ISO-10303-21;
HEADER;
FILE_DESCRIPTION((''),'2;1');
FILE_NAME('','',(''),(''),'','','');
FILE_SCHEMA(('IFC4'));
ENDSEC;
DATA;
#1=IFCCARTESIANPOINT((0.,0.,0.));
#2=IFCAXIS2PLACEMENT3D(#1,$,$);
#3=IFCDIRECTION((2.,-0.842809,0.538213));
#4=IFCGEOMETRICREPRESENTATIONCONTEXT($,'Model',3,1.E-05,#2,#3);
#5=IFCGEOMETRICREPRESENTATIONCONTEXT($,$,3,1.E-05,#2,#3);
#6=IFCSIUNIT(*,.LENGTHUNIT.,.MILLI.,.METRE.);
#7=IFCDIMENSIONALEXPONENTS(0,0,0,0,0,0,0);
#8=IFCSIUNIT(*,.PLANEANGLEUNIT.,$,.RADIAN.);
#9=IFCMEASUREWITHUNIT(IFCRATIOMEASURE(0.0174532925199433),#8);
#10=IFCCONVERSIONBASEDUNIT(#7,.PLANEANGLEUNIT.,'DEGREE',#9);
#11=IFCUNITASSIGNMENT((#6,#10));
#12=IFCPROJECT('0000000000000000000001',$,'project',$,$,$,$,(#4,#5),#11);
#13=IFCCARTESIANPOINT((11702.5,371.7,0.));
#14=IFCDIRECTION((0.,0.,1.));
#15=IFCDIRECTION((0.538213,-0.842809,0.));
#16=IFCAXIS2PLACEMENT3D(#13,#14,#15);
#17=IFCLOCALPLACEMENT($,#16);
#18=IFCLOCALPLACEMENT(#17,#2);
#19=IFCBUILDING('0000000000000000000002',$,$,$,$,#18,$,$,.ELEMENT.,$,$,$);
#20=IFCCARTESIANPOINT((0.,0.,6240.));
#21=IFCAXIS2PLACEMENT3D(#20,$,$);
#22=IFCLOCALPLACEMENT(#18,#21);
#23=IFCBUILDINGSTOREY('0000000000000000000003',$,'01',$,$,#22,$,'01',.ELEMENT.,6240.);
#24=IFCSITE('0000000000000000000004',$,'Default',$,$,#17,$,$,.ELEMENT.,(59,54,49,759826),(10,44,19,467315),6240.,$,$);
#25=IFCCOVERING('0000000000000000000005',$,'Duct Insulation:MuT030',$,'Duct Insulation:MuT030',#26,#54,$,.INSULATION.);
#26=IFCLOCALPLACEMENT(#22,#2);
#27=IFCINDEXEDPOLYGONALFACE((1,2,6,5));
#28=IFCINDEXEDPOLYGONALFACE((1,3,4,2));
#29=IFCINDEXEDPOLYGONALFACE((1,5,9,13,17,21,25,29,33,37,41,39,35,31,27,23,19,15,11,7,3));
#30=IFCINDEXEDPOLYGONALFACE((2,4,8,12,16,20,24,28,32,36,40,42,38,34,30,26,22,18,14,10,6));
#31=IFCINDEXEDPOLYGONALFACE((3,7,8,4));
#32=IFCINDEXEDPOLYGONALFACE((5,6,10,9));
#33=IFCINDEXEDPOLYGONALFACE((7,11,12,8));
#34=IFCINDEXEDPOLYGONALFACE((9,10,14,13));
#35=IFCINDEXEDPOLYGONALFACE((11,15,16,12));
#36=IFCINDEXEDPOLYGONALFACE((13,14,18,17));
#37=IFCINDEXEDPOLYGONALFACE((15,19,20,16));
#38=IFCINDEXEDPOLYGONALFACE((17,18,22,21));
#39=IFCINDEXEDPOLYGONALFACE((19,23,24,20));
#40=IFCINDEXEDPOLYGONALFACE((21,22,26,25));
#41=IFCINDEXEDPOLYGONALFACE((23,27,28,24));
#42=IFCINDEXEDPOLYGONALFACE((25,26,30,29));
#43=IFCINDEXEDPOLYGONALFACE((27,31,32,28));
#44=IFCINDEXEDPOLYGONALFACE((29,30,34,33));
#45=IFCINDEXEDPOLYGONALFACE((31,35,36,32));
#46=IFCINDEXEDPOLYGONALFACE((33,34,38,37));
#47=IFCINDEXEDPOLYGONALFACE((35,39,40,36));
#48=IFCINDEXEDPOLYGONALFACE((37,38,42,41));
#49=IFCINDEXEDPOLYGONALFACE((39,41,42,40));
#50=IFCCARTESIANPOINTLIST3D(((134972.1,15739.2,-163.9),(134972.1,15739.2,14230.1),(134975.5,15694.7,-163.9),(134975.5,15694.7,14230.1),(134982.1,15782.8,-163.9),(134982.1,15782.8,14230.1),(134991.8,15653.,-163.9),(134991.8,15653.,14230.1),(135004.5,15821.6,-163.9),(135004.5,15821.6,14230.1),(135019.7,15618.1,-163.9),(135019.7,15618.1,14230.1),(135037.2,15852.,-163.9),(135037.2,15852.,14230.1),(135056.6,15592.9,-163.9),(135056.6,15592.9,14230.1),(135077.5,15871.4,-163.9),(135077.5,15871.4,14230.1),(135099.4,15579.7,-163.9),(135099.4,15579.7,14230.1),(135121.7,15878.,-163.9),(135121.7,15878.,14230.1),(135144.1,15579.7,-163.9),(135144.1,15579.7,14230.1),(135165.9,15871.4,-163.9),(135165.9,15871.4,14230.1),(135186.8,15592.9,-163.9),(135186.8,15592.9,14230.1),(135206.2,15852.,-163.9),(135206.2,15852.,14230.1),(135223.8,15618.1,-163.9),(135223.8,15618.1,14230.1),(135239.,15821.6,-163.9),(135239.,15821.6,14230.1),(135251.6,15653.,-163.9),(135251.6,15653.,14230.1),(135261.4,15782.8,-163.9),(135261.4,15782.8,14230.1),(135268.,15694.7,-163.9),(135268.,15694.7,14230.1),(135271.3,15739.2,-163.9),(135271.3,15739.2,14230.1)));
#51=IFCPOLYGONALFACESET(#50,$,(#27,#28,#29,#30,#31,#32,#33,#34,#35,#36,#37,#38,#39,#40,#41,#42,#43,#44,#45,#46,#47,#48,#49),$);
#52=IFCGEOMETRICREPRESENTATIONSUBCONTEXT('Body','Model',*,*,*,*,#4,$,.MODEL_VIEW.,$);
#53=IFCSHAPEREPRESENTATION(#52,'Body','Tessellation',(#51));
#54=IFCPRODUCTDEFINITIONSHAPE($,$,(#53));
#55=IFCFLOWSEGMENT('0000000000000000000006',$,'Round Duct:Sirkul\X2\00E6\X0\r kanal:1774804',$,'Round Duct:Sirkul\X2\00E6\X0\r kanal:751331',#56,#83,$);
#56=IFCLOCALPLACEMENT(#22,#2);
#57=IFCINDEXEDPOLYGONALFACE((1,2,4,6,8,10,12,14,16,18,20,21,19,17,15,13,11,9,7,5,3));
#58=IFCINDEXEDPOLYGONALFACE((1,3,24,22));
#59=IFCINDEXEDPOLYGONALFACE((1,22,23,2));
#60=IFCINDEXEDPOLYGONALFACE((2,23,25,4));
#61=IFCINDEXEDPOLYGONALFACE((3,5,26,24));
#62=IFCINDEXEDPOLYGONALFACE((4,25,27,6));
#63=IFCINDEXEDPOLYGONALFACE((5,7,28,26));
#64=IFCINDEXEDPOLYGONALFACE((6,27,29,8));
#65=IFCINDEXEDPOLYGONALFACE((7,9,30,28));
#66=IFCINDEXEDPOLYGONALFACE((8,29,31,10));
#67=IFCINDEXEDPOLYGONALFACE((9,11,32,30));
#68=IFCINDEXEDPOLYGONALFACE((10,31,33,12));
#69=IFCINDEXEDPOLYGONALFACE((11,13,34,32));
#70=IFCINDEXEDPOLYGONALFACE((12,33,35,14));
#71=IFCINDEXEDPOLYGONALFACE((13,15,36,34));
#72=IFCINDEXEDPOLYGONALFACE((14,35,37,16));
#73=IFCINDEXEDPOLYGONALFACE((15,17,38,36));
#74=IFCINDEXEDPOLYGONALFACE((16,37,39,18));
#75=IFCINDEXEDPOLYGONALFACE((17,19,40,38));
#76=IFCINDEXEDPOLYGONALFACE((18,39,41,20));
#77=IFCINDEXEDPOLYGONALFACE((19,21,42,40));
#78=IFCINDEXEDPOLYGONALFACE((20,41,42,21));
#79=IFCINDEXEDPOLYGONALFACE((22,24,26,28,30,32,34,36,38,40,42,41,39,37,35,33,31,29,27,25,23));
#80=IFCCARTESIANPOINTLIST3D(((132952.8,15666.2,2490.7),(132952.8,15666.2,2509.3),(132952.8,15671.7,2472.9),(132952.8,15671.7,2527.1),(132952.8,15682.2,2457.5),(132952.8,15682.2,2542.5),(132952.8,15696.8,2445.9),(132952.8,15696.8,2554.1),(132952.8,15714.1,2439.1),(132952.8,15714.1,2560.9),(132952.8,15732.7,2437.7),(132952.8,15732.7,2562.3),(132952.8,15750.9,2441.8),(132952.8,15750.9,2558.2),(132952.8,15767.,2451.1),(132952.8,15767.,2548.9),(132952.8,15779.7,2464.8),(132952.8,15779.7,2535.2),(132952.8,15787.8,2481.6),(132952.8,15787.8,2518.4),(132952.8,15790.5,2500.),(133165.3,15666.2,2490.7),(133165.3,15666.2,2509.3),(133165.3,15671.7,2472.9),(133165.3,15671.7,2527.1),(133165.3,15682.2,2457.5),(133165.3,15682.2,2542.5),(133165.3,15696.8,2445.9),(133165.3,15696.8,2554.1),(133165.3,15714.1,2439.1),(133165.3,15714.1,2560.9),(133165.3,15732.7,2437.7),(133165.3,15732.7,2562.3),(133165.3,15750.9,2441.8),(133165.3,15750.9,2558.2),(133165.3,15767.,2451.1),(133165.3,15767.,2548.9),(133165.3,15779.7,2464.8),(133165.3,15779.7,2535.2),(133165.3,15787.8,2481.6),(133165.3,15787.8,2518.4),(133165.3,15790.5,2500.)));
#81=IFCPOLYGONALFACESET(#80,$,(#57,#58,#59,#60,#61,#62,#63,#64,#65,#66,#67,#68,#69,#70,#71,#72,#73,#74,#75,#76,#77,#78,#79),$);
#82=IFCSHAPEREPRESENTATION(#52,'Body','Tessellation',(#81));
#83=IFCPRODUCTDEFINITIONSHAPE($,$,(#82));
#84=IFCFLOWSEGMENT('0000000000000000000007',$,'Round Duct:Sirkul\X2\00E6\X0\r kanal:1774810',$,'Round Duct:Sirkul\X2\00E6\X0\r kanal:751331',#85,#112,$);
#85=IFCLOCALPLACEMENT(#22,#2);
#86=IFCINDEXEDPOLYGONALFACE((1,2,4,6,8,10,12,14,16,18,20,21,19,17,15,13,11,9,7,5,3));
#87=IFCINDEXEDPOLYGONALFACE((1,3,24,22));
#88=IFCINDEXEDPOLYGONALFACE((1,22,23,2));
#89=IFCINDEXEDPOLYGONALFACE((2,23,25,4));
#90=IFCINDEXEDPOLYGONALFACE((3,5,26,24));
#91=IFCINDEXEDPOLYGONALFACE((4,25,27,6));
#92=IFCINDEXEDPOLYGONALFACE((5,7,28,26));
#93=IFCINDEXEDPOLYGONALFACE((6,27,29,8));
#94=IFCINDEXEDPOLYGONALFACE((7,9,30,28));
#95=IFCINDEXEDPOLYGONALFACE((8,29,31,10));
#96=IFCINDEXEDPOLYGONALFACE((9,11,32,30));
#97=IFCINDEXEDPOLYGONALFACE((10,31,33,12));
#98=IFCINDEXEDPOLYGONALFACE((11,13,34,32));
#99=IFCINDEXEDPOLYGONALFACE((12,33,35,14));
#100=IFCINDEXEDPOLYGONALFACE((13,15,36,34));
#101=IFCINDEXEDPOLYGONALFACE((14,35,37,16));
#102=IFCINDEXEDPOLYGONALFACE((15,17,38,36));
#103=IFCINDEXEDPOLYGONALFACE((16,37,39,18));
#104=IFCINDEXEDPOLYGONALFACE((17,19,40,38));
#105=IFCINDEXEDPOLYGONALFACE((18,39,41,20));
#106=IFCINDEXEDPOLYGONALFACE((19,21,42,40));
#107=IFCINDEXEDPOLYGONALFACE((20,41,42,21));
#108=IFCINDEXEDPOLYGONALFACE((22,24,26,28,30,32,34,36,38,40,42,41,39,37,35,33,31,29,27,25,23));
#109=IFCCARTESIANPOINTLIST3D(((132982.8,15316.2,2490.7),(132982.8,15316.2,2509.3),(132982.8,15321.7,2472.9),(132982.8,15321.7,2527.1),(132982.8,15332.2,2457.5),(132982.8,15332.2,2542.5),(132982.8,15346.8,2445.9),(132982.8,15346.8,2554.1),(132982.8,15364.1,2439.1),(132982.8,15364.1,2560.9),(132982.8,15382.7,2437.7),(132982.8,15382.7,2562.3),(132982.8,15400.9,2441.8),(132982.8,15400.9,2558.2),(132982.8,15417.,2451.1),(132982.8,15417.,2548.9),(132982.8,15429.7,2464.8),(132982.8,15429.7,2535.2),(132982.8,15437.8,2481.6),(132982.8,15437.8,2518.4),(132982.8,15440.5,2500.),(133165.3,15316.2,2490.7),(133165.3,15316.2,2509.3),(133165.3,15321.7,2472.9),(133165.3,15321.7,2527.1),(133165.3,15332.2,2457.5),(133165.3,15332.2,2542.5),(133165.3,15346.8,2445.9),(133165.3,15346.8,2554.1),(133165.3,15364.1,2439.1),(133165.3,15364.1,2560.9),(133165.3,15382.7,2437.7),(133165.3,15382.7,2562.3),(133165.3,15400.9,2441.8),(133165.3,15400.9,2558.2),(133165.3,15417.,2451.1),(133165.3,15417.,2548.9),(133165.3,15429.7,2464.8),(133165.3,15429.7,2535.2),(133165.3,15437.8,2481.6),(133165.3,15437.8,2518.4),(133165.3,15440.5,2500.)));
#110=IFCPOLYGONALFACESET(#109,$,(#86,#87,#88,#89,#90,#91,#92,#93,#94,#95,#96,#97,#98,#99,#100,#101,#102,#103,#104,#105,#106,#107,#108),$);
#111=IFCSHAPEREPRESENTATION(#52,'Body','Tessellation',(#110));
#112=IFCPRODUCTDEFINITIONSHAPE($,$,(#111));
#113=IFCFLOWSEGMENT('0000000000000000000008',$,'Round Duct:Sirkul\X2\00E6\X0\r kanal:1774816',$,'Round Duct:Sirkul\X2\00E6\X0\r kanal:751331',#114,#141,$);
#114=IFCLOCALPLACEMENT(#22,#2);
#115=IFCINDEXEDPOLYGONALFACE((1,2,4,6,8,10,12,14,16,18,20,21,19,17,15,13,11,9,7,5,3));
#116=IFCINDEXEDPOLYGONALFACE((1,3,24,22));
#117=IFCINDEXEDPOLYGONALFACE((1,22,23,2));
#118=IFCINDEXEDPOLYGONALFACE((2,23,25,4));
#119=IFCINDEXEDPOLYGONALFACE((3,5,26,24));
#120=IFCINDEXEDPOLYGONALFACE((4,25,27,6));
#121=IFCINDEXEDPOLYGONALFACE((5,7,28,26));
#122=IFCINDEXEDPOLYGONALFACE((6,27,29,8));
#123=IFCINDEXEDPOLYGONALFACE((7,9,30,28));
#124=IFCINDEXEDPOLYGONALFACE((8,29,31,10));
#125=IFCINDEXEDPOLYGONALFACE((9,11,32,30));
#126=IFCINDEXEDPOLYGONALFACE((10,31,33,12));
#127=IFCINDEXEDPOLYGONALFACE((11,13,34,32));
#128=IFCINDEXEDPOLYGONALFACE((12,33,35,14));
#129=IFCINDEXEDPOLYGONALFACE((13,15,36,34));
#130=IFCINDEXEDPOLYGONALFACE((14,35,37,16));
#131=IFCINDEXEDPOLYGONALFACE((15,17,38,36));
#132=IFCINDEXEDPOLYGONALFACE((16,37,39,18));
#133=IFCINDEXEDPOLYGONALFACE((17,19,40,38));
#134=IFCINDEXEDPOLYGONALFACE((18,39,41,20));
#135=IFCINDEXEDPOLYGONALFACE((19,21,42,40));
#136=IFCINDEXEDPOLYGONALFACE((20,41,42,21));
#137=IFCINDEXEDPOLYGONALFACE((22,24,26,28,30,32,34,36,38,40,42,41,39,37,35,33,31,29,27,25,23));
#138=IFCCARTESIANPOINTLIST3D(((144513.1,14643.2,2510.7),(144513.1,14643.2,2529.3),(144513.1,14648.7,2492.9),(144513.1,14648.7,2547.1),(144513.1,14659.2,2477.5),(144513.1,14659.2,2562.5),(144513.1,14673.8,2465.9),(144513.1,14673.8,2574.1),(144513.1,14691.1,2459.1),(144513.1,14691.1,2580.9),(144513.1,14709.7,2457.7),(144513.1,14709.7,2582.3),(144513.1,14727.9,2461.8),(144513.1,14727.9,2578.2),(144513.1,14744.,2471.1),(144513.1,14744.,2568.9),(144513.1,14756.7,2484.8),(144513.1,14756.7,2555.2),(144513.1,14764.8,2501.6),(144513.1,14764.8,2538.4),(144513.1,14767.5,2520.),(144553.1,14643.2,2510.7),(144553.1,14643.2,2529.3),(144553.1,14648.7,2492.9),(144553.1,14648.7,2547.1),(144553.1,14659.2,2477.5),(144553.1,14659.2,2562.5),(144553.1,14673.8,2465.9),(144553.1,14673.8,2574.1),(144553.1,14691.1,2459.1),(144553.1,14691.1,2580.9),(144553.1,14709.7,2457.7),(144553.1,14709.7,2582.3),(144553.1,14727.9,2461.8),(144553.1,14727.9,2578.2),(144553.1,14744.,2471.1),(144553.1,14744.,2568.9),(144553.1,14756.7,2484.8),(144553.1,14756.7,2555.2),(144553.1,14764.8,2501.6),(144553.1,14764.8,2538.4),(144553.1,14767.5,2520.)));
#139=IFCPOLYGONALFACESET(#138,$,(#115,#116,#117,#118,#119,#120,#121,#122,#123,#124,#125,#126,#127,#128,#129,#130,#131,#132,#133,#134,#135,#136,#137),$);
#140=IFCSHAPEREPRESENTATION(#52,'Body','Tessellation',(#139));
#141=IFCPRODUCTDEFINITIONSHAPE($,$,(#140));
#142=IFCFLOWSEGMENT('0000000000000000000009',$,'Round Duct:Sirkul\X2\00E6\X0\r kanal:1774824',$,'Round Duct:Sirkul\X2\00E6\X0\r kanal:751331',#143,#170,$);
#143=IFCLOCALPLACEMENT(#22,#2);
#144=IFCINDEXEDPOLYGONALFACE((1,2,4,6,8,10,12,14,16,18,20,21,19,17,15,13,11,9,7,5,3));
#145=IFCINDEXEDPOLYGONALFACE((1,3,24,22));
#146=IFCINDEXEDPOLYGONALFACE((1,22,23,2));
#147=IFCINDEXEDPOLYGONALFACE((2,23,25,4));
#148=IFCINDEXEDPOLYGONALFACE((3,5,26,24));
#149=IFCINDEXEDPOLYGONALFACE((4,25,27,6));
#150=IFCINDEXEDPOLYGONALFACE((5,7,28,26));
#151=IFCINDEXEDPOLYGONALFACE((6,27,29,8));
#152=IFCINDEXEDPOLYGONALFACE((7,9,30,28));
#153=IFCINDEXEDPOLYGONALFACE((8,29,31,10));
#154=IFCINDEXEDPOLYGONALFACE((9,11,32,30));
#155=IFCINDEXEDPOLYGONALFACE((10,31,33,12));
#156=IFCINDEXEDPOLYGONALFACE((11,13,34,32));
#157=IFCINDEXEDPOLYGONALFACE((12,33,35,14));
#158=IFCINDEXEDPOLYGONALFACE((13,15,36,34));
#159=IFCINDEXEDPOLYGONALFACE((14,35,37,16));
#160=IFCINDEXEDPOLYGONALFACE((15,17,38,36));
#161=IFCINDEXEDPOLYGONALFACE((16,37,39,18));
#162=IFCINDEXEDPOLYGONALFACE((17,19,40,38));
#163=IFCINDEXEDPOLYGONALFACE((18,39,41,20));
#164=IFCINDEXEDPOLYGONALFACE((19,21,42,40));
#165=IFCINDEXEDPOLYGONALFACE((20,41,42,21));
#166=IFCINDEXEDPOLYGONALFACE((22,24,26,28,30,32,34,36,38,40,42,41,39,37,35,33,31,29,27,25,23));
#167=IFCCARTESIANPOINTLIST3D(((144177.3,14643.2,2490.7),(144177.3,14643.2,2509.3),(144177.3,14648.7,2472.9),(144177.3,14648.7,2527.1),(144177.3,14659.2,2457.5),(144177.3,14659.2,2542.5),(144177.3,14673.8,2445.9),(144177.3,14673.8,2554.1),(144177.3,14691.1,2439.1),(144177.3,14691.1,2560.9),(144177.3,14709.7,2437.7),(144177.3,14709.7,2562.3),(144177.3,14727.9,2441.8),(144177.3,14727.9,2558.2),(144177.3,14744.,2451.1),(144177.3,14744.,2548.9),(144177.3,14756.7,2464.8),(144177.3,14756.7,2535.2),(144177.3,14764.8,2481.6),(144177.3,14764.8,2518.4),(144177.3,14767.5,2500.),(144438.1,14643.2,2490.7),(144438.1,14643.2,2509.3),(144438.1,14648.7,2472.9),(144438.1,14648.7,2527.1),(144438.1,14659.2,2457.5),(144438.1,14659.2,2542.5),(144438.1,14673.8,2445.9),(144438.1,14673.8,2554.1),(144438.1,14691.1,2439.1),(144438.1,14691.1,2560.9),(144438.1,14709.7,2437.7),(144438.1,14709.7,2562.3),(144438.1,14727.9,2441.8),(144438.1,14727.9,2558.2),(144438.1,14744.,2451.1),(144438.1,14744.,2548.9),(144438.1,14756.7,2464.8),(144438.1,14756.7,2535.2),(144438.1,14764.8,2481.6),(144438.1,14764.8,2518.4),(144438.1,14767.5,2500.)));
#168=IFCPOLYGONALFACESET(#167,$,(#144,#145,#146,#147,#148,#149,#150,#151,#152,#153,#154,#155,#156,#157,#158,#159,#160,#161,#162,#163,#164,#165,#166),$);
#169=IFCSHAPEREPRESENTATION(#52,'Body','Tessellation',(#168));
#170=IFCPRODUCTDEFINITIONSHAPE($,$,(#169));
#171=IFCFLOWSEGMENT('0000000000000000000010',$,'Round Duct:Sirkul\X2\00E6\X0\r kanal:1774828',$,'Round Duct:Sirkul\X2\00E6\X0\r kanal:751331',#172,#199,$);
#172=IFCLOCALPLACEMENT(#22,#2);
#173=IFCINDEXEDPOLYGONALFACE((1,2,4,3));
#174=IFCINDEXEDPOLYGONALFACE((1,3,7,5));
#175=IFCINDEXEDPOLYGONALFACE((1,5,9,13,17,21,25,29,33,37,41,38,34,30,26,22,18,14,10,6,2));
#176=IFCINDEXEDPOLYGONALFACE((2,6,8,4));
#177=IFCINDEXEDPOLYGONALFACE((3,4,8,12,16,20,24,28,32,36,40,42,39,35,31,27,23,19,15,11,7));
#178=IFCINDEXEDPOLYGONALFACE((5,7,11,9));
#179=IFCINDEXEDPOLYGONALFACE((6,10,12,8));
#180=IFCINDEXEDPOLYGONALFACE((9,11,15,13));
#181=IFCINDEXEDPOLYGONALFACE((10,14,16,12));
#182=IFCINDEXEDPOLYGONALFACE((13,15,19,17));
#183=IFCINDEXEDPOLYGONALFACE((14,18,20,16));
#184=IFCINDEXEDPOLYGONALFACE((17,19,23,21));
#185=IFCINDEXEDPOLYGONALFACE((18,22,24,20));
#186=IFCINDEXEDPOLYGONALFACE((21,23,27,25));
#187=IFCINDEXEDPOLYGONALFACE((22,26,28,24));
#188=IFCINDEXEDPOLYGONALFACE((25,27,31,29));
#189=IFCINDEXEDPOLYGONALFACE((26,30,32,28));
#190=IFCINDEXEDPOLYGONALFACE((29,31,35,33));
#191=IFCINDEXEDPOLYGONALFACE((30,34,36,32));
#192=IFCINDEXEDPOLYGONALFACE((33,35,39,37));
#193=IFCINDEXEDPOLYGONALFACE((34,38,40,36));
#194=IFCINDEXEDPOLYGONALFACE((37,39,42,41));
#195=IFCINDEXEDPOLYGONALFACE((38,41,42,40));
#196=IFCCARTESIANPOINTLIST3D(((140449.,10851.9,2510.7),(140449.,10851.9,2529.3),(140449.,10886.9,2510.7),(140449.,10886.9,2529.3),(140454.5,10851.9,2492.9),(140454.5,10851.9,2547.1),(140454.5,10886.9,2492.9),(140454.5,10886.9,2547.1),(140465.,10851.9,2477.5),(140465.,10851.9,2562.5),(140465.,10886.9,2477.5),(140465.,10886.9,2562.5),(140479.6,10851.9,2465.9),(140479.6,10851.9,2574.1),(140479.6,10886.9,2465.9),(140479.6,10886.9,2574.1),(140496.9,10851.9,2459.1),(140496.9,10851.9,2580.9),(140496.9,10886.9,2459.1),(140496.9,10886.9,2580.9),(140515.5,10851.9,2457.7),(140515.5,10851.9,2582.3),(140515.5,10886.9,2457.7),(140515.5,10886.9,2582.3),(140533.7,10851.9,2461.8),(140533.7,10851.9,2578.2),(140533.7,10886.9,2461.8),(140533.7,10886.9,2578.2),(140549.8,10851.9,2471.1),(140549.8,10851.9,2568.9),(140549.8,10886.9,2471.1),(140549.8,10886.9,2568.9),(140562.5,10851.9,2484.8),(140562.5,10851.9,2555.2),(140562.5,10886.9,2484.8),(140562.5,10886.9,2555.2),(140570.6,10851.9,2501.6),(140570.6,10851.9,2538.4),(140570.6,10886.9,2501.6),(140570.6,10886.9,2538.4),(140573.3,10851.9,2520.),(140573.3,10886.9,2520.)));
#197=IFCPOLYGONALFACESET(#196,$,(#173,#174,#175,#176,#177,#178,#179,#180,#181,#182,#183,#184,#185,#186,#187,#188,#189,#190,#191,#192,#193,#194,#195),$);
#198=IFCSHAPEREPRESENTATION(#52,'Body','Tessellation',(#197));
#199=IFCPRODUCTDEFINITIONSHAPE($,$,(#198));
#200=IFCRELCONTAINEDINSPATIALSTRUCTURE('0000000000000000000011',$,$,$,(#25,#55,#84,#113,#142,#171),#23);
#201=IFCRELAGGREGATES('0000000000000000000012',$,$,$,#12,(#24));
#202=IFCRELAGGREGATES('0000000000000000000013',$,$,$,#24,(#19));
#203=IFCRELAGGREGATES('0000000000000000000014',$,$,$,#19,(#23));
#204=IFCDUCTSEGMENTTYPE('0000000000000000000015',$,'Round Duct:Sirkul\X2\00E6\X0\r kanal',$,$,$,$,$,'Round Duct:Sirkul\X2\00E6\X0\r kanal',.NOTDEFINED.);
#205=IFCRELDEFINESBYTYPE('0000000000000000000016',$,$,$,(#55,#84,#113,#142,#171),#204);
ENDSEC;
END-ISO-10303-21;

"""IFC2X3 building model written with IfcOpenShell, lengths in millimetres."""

from ifc_helpers import new_model, entity, si_unit, converted_unit, direction, frame, frame_2d, origin, origin_2d_with_axis, place, context, subcontext, project, spatial, circle, extrude, type_object, element, save


model = new_model("IFC2X3")

# Units and contexts
model_context = context("Model", 3, precision=1e-05, world=origin(), true_north=direction((2.0, -0.842809, 0.538213)))
context_of_model = context(None, 3, precision=1e-05, world=origin(), true_north=direction((2.0, -0.842809, 0.538213)))
body_context = subcontext(model_context, "Body", "Model", "MODEL_VIEW")
ifc_project = project(units=[si_unit("LENGTHUNIT", "METRE", prefix="MILLI"), converted_unit("PLANEANGLEUNIT", "DEGREE", entity("IfcRatioMeasure", 0.0174532925199433), si_unit("PLANEANGLEUNIT", "RADIAN"), dimensions=[0, 0, 0, 0, 0, 0, 0])], contexts=[model_context, context_of_model])

# Site, building, storey
site_placement = place(None, frame((11702.5, 371.7, 0.0), z_axis=(0.0, 0.0, 1.0), x_axis=(0.538213, -0.842809, 0.0)))
site = spatial("IfcSite", under=ifc_project, at=site_placement, Name="Default", CompositionType="ELEMENT", RefLatitude=(59, 54, 49, 759826), RefLongitude=(10, 44, 19, 467315), RefElevation=6240.0)
building_placement = place(site_placement, origin())
building = spatial("IfcBuilding", under=site, at=building_placement, CompositionType="ELEMENT")
storey_placement = place(building_placement, frame((0.0, 0.0, 6240.0)))
storey = spatial("IfcBuildingStorey", under=building, at=storey_placement, Name="01", LongName="01", CompositionType="ELEMENT", Elevation=6240.0)

# Covering
covering_placement = place(storey_placement, origin())
element("IfcCovering", 1, at=covering_placement, inside=storey, Name="Duct Insulation:MuT030", ObjectType="Duct Insulation:MuT030", PredefinedType="INSULATION", context=body_context, shape_type="SweptSolid", body=[
    extrude(circle(Radius=150.0, at=frame_2d((0.0, 0.0), x_axis=(1.0, 0.0))), frame((135121.7, 15728.0, -163.9), z_axis=(0.0, 0.0, 1.0), x_axis=(0.0, 1.0, 0.0)), (0.0, 0.0, 1.0), 14394.0),
])

# Flow segments
duct_segment_type_1 = type_object("IfcDuctSegmentType", Name="Round Duct:Sirkulær kanal", ElementType="Round Duct:Sirkulær kanal", PredefinedType="NOTDEFINED")
flow_segment_1_placement = place(storey_placement, origin())
element("IfcFlowSegment", 2, at=flow_segment_1_placement, inside=storey, type_object=duct_segment_type_1, Name="Round Duct:Sirkulær kanal:1774804", ObjectType="Round Duct:Sirkulær kanal:751331", context=body_context, shape_type="SweptSolid", body=[
    extrude(circle(Radius=62.5, at=frame_2d((0.0, 0.0), x_axis=(1.0, 0.0))), frame((132952.8, 15728.0, 2500.0), z_axis=(1.0, 0.0, 0.0), x_axis=(0.0, 1.0, 0.0)), (0.0, 0.0, 1.0), 212.5),
])
flow_segment_2_placement = place(storey_placement, origin())
element("IfcFlowSegment", 3, at=flow_segment_2_placement, inside=storey, type_object=duct_segment_type_1, Name="Round Duct:Sirkulær kanal:1774810", ObjectType="Round Duct:Sirkulær kanal:751331", context=body_context, shape_type="SweptSolid", body=[
    extrude(circle(Radius=62.5, at=frame_2d((0.0, 0.0), x_axis=(1.0, 0.0))), frame((132982.8, 15378.0, 2500.0), z_axis=(1.0, 0.0, 0.0), x_axis=(0.0, 1.0, 0.0)), (0.0, 0.0, 1.0), 182.5),
])
flow_segment_3_placement = place(storey_placement, origin())
element("IfcFlowSegment", 4, at=flow_segment_3_placement, inside=storey, type_object=duct_segment_type_1, Name="Round Duct:Sirkulær kanal:1774816", ObjectType="Round Duct:Sirkulær kanal:751331", context=body_context, shape_type="SweptSolid", body=[
    extrude(circle(Radius=62.5, at=origin_2d_with_axis()), frame((144513.1, 14705.0, 2520.0), z_axis=(1.0, 0.0, 0.0), x_axis=(0.0, 1.0, 0.0)), (0.0, 0.0, 1.0), 40.0),
])
flow_segment_4_placement = place(storey_placement, origin())
element("IfcFlowSegment", 5, at=flow_segment_4_placement, inside=storey, type_object=duct_segment_type_1, Name="Round Duct:Sirkulær kanal:1774824", ObjectType="Round Duct:Sirkulær kanal:751331", context=body_context, shape_type="SweptSolid", body=[
    extrude(circle(Radius=62.5, at=origin_2d_with_axis()), frame((144177.3, 14705.0, 2500.0), z_axis=(1.0, 0.0, 0.0), x_axis=(0.0, 1.0, 0.0)), (0.0, 0.0, 1.0), 260.8),
])
flow_segment_5_placement = place(storey_placement, origin())
element("IfcFlowSegment", 6, at=flow_segment_5_placement, inside=storey, type_object=duct_segment_type_1, Name="Round Duct:Sirkulær kanal:1774828", ObjectType="Round Duct:Sirkulær kanal:751331", context=body_context, shape_type="SweptSolid", body=[
    extrude(circle(Radius=62.5, at=frame_2d((0.0, 0.0), x_axis=(1.0, 0.0))), frame((140510.8, 10851.9, 2520.0), z_axis=(0.0, 1.0, 0.0), x_axis=(1.0, 0.0, 0.0)), (0.0, 0.0, 1.0), 35.0),
])

save(model, "model.ifc")
